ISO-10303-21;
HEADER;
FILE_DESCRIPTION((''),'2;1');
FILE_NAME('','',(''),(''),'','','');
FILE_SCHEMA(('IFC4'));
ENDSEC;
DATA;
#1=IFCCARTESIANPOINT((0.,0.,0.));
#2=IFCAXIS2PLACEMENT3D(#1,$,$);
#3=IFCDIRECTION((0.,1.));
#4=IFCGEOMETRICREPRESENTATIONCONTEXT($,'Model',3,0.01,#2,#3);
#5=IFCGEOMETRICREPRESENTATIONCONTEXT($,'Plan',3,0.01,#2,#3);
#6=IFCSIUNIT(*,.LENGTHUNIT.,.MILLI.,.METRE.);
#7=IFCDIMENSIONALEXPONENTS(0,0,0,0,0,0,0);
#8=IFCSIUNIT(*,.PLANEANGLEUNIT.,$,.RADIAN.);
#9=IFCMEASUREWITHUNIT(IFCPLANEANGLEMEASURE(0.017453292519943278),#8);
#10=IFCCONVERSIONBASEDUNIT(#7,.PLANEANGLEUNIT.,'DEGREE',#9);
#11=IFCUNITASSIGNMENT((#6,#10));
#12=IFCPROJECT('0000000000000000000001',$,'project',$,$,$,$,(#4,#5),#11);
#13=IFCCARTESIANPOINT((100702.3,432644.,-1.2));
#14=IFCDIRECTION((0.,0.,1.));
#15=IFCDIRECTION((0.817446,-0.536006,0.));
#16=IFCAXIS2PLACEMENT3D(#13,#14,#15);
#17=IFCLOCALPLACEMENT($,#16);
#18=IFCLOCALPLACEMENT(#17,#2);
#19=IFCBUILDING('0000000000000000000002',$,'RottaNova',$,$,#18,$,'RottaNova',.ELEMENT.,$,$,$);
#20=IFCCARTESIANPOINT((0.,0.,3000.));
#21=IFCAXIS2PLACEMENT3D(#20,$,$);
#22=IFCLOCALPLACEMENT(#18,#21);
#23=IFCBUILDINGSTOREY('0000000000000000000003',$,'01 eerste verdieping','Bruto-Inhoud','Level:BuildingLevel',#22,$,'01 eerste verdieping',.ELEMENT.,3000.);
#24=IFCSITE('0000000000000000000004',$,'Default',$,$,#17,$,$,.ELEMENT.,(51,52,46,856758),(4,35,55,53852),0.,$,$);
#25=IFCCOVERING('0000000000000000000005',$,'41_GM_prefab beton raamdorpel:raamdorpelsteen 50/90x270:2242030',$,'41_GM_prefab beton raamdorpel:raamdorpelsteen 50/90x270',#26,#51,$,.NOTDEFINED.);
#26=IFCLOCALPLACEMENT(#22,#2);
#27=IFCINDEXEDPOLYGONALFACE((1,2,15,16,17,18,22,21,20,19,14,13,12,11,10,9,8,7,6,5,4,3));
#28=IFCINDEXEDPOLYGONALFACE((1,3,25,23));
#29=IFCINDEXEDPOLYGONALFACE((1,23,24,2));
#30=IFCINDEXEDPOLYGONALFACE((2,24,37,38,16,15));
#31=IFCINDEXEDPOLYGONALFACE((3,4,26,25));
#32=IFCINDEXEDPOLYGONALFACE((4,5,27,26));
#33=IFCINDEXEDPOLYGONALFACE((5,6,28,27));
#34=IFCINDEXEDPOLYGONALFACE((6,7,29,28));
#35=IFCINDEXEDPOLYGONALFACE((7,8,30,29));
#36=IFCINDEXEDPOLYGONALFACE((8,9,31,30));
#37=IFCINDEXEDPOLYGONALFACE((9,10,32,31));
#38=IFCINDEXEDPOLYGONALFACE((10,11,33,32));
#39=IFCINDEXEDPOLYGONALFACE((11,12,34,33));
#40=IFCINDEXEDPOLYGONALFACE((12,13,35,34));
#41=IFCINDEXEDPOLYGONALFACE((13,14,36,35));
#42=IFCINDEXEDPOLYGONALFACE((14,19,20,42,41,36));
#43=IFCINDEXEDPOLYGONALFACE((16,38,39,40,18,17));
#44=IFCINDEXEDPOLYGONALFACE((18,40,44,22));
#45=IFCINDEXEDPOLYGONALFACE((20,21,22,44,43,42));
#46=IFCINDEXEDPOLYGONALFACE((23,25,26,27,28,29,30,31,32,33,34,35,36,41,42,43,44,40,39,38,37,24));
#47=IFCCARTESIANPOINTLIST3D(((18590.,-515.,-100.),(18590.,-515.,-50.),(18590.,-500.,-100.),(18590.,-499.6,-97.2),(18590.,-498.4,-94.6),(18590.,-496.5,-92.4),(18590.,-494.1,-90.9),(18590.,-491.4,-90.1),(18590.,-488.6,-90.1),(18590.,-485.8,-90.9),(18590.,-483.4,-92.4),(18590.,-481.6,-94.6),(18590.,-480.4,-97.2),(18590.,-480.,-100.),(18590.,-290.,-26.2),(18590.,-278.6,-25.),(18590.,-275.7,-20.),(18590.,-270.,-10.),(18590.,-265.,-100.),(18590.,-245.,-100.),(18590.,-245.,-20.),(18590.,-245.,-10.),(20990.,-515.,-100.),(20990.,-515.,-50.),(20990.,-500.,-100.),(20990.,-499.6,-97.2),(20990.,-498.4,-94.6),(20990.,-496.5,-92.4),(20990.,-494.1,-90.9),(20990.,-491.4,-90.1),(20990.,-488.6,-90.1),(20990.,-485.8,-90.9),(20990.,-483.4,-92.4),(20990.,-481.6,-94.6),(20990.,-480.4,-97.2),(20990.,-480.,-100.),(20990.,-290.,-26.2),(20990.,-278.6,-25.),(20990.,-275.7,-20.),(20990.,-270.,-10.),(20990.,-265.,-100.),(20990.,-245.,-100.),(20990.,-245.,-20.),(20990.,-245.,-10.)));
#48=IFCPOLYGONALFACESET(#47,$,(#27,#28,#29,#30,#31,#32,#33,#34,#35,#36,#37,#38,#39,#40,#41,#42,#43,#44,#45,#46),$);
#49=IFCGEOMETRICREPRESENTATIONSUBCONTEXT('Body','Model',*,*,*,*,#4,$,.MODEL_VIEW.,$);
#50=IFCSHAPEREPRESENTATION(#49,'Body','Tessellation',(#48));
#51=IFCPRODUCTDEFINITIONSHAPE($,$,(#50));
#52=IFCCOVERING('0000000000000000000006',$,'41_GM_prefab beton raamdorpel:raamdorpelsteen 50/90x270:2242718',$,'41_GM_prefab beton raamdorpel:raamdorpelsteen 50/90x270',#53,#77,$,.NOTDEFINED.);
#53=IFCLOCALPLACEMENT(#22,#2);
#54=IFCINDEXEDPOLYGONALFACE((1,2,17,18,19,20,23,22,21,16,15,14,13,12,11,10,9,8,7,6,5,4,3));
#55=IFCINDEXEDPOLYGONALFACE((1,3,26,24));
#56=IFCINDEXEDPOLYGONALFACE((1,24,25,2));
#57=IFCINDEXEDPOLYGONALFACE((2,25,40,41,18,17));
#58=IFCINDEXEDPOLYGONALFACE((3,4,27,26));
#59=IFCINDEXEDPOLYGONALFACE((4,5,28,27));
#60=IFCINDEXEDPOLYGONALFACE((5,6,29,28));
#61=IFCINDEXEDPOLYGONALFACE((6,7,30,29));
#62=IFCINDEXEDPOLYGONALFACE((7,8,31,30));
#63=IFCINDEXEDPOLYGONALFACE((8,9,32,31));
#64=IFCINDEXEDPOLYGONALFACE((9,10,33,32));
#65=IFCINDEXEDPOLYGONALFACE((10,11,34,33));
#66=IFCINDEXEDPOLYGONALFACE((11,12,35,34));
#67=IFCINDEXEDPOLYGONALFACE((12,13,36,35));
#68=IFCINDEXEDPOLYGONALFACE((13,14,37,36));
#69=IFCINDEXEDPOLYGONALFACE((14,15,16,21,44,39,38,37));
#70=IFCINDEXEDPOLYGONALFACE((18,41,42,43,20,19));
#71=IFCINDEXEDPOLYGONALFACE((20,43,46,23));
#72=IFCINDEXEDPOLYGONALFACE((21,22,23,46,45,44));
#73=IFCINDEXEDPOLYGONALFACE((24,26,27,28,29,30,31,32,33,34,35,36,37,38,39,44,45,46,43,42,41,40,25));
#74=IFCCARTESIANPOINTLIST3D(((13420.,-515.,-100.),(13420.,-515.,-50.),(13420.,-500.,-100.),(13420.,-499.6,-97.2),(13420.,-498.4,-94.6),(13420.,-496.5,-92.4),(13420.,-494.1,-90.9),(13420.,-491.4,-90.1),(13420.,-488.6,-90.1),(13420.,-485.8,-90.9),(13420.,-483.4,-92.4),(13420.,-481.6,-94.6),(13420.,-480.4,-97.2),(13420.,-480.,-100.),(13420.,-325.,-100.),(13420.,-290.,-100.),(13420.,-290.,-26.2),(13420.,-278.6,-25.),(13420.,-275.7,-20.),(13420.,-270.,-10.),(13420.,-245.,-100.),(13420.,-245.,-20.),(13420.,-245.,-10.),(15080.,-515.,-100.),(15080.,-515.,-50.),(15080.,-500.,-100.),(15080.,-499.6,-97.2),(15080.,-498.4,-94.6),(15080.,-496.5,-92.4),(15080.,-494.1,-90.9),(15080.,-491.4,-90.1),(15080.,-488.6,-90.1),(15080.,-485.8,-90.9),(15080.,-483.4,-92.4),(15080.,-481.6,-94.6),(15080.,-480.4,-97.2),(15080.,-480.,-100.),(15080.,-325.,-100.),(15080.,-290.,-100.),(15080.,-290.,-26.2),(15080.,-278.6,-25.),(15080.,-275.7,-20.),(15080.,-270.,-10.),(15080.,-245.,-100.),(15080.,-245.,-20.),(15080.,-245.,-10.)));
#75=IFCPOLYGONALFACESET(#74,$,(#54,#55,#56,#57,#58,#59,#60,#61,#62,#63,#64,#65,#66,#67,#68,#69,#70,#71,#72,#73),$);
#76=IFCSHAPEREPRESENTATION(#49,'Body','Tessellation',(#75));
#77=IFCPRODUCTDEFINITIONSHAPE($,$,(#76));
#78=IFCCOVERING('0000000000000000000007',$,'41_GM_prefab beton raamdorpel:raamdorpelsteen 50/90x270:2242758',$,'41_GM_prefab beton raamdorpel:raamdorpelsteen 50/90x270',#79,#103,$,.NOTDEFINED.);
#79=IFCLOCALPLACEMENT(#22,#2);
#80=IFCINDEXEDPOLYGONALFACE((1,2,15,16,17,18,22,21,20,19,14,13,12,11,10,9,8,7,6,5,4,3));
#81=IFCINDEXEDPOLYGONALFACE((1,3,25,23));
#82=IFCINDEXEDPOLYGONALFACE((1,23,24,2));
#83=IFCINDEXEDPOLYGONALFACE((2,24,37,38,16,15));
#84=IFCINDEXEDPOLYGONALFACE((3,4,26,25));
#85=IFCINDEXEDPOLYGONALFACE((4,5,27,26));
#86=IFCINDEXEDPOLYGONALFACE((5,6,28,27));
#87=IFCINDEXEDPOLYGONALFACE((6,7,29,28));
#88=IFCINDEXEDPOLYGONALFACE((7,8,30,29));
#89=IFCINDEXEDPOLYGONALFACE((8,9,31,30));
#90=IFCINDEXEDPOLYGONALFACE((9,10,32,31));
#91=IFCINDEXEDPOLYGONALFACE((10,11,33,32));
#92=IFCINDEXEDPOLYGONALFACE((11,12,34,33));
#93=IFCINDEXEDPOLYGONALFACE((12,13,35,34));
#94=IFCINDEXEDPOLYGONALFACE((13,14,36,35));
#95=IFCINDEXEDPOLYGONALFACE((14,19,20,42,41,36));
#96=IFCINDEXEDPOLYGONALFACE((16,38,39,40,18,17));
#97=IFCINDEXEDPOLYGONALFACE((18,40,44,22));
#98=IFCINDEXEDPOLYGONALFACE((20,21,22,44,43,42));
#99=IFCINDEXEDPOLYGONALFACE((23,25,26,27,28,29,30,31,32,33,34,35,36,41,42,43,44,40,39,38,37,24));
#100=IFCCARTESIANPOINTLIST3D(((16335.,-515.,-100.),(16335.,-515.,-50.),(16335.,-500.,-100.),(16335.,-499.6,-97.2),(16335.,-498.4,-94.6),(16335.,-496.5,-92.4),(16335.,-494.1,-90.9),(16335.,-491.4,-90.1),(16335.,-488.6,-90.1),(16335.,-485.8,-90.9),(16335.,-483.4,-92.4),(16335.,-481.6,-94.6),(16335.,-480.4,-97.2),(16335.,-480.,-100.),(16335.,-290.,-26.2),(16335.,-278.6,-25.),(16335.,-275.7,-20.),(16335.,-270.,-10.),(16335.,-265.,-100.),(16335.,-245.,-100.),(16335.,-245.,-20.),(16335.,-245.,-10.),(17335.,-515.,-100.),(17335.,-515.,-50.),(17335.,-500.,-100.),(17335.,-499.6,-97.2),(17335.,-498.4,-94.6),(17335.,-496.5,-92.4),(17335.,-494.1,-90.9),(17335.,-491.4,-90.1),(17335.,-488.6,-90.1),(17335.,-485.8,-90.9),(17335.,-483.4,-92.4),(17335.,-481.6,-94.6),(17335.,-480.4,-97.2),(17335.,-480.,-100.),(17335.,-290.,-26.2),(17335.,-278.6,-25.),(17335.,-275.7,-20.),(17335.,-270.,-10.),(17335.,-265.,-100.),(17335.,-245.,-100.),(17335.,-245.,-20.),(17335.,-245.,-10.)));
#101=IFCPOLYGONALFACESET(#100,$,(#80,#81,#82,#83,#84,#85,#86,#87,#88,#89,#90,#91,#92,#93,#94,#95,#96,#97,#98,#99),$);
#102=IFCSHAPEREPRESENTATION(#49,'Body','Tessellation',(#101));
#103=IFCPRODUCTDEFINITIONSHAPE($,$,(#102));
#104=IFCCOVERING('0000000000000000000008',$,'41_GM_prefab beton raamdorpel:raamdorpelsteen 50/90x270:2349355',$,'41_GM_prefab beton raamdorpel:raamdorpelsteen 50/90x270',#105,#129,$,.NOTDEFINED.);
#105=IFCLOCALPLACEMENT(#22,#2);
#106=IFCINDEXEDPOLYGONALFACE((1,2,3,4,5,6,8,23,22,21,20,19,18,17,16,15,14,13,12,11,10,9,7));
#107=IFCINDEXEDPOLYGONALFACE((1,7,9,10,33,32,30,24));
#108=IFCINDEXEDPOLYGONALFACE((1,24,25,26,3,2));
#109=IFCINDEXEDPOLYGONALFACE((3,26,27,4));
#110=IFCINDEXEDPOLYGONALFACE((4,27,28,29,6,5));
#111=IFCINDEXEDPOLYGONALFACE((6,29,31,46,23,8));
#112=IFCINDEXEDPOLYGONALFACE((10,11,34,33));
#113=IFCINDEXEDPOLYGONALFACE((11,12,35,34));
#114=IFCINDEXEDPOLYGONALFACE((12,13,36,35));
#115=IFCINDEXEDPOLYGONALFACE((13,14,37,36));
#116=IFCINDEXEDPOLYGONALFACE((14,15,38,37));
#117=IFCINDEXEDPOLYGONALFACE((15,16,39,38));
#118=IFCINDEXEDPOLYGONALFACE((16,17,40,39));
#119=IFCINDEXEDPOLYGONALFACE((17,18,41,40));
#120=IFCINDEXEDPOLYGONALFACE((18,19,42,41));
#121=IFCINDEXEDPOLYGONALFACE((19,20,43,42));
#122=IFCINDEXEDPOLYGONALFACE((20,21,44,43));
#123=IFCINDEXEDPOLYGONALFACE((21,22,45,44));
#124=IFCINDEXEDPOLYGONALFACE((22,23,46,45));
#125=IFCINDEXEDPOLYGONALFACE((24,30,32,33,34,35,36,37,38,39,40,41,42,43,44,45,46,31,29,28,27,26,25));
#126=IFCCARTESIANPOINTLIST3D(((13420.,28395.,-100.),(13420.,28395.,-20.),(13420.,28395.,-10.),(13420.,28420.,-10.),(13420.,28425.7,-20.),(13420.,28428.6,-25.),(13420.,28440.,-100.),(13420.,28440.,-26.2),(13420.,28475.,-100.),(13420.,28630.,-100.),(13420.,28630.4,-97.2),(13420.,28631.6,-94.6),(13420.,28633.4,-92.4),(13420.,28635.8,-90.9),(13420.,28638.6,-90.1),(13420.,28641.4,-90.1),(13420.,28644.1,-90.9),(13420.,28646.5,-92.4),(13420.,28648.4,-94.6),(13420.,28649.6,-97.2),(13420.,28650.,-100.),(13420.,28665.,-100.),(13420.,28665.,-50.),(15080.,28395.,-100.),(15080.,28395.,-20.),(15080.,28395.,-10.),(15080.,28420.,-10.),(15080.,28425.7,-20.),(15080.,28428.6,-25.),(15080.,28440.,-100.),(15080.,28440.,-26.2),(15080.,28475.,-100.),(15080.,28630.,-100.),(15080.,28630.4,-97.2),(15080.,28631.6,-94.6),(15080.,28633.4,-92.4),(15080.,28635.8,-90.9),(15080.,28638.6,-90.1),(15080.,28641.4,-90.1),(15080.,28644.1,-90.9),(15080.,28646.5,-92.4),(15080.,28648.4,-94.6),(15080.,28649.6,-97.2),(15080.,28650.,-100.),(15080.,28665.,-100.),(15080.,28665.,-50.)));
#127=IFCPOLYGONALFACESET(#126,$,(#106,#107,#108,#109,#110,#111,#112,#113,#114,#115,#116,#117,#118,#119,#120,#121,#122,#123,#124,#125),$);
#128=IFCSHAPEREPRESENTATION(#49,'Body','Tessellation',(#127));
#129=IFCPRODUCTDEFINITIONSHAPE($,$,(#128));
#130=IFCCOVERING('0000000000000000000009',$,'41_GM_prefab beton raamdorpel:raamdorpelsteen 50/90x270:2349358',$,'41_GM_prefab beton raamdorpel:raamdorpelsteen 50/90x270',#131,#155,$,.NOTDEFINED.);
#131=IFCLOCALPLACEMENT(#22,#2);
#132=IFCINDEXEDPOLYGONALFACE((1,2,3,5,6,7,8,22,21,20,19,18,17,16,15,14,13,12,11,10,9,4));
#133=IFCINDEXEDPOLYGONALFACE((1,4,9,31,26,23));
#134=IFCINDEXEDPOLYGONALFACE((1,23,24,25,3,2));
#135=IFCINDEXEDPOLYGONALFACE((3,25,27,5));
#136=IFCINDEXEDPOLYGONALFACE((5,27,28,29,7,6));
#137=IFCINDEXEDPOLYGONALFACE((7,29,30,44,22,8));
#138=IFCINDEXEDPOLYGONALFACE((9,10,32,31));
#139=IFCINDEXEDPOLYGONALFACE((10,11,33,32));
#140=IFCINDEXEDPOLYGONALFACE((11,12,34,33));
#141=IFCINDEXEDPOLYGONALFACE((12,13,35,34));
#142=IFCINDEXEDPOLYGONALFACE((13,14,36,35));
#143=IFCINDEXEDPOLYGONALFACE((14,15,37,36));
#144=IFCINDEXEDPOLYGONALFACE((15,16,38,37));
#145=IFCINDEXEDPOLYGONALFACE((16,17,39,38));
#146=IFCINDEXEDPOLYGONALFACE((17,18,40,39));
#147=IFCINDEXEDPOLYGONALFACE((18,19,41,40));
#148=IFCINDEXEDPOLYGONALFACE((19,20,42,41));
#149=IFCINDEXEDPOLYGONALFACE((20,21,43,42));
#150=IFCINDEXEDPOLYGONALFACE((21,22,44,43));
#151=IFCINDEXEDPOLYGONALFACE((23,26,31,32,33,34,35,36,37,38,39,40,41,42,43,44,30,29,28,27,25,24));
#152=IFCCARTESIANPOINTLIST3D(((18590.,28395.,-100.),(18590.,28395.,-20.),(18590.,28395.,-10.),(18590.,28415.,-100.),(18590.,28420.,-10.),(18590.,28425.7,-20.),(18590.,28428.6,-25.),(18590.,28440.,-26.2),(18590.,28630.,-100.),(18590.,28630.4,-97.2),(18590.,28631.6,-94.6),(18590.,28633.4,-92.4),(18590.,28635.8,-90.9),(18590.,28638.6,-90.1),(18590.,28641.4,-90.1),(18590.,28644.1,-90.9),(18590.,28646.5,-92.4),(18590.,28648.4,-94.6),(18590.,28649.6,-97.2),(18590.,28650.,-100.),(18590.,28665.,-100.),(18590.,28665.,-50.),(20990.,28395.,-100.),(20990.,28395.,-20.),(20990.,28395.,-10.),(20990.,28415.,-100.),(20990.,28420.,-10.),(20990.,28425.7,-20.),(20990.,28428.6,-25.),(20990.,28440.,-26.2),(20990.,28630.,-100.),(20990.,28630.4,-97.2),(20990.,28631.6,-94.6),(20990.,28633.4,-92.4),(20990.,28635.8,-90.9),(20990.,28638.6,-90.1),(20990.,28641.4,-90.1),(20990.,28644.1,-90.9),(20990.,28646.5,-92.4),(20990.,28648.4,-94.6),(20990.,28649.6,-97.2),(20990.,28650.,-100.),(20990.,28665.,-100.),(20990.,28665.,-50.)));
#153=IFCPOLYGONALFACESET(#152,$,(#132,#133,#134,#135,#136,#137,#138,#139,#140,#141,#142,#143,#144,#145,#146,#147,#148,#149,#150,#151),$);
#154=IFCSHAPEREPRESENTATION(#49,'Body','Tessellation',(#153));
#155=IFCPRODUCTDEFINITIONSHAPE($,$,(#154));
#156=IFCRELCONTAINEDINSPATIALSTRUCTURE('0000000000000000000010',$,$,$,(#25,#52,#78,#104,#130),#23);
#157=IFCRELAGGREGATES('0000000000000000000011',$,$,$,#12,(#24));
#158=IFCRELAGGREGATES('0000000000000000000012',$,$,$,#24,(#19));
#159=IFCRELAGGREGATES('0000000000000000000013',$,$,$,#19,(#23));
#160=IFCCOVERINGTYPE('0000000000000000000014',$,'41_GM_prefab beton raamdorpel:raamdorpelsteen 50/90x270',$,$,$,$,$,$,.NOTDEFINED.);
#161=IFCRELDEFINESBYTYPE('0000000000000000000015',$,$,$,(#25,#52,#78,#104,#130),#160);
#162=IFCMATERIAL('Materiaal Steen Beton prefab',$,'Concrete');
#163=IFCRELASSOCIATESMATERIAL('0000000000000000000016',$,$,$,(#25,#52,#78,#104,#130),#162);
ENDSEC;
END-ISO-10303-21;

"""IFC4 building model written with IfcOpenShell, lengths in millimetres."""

from ifc_helpers import new_model, entity, si_unit, converted_unit, direction, frame, origin, place, context, subcontext, project, spatial, line, arc, indexed_curve, outline, extrude, material, type_object, element, save


model = new_model("IFC4")

# Units and contexts
model_context = context("Model", 3, precision=0.01, world=origin(), true_north=direction((0.0, 1.0)))
plan_context = context("Plan", 3, precision=0.01, world=origin(), true_north=direction((0.0, 1.0)))
body_context = subcontext(model_context, "Body", "Model", "MODEL_VIEW")
ifc_project = project(units=[si_unit("LENGTHUNIT", "METRE", prefix="MILLI"), converted_unit("PLANEANGLEUNIT", "DEGREE", entity("IfcPlaneAngleMeasure", 0.017453292519943278), si_unit("PLANEANGLEUNIT", "RADIAN"), dimensions=[0, 0, 0, 0, 0, 0, 0])], contexts=[model_context, plan_context])

# Site, building, storey
site_placement = place(None, frame((100702.3, 432644.0, -1.2), z_axis=(0.0, 0.0, 1.0), x_axis=(0.817446, -0.536006, 0.0)))
site = spatial("IfcSite", under=ifc_project, at=site_placement, Name="Default", CompositionType="ELEMENT", RefLatitude=(51, 52, 46, 856758), RefLongitude=(4, 35, 55, 53852), RefElevation=0.0)
building_placement = place(site_placement, origin())
building = spatial("IfcBuilding", under=site, at=building_placement, Name="RottaNova", LongName="RottaNova", CompositionType="ELEMENT")
storey_placement = place(building_placement, frame((0.0, 0.0, 3000.0)))
storey = spatial("IfcBuildingStorey", under=building, at=storey_placement, Name="01 eerste verdieping", Description="Bruto-Inhoud", ObjectType="Level:BuildingLevel", LongName="01 eerste verdieping", CompositionType="ELEMENT", Elevation=3000.0)

# Shared definitions
ifc_material_1 = material(Name="Materiaal Steen Beton prefab", Category="Concrete")

# Coverings
covering_type_1 = type_object("IfcCoveringType", Name="41_GM_prefab beton raamdorpel:raamdorpelsteen 50/90x270", PredefinedType="NOTDEFINED")
covering_1_placement = place(storey_placement, origin())
element("IfcCovering", 1, at=covering_1_placement, inside=storey, type_object=covering_type_1, material=ifc_material_1, Name="41_GM_prefab beton raamdorpel:raamdorpelsteen 50/90x270:2242030", ObjectType="41_GM_prefab beton raamdorpel:raamdorpelsteen 50/90x270", PredefinedType="NOTDEFINED", context=body_context, shape_type="SweptSolid", body=[
    extrude(outline(indexed_curve([(-75.9, -41.3), (-88.4, -62.9), (-79.8, -67.9), (-10.5, -107.9), (-0.5, -90.6), (107.0, 95.6), (103.4, 109.3), (117.0, 112.9), (124.5, 125.9), (81.2, 150.9), (-51.9, -32.0), (-58.6, -41.3), (-64.4, -41.3)], segments=[line(1, 2, 3, 4, 5, 6), arc(6, 7, 8), line(8, 9, 10, 11, 12, 13, 1)], self_intersect=False)), frame((18590.0, -343.7, -55.1), z_axis=(-1.0, 0.0, 0.0), x_axis=(0.0, -0.5, -0.866025)), (0.0, 0.0, -1.0), 2400.0),
])
covering_2_placement = place(storey_placement, origin())
element("IfcCovering", 2, at=covering_2_placement, inside=storey, type_object=covering_type_1, material=ifc_material_1, Name="41_GM_prefab beton raamdorpel:raamdorpelsteen 50/90x270:2242718", ObjectType="41_GM_prefab beton raamdorpel:raamdorpelsteen 50/90x270", PredefinedType="NOTDEFINED", context=body_context, shape_type="SweptSolid", body=[
    extrude(outline(indexed_curve([(-79.1, -40.0), (-91.6, -61.6), (-83.0, -66.6), (-13.7, -106.6), (8.8, -67.6), (26.3, -37.3), (103.8, 96.9), (100.1, 110.6), (113.8, 114.2), (121.3, 127.2), (78.0, 152.2), (-55.1, -30.7), (-61.8, -40.0), (-67.6, -40.0)], segments=[line(1, 2, 3, 4, 5, 6, 7), arc(7, 8, 9), line(9, 10, 11, 12, 13, 14, 1)], self_intersect=False)), frame((13420.0, -344.2, -58.6), z_axis=(-1.0, 0.0, 0.0), x_axis=(0.0, -0.5, -0.866025)), (0.0, 0.0, -1.0), 1660.0),
])
covering_3_placement = place(storey_placement, origin())
element("IfcCovering", 3, at=covering_3_placement, inside=storey, type_object=covering_type_1, material=ifc_material_1, Name="41_GM_prefab beton raamdorpel:raamdorpelsteen 50/90x270:2242758", ObjectType="41_GM_prefab beton raamdorpel:raamdorpelsteen 50/90x270", PredefinedType="NOTDEFINED", context=body_context, shape_type="SweptSolid", body=[
    extrude(outline(indexed_curve([(-75.9, -41.3), (-88.4, -62.9), (-79.8, -67.9), (-10.5, -107.9), (-0.5, -90.6), (107.0, 95.6), (103.4, 109.3), (117.0, 112.9), (124.5, 125.9), (81.2, 150.9), (-51.9, -32.0), (-58.6, -41.3), (-64.4, -41.3)], segments=[line(1, 2, 3, 4, 5, 6), arc(6, 7, 8), line(8, 9, 10, 11, 12, 13, 1)], self_intersect=False)), frame((16335.0, -343.7, -55.1), z_axis=(-1.0, 0.0, 0.0), x_axis=(0.0, -0.5, -0.866025)), (0.0, 0.0, -1.0), 1000.0),
])
covering_4_placement = place(storey_placement, origin())
element("IfcCovering", 4, at=covering_4_placement, inside=storey, type_object=covering_type_1, material=ifc_material_1, Name="41_GM_prefab beton raamdorpel:raamdorpelsteen 50/90x270:2349355", ObjectType="41_GM_prefab beton raamdorpel:raamdorpelsteen 50/90x270", PredefinedType="NOTDEFINED", context=body_context, shape_type="SweptSolid", body=[
    extrude(outline(indexed_curve([(74.2, -48.6), (99.2, -48.6), (99.2, -38.6), (99.2, 41.4), (54.2, 41.4), (19.2, 41.4), (-135.8, 41.4), (-145.8, 31.4), (-155.8, 41.4), (-170.8, 41.4), (-170.8, -8.6), (54.2, -32.4), (65.5, -33.6), (68.4, -38.6)], segments=[line(1, 2, 3, 4, 5, 6, 7), arc(7, 8, 9), line(9, 10, 11, 12, 13, 14, 1)], self_intersect=False)), frame((13420.0, 28494.2, -58.6), z_axis=(1.0, 0.0, 0.0), x_axis=(0.0, -1.0, 0.0)), (0.0, 0.0, 1.0), 1660.0),
])
covering_5_placement = place(storey_placement, origin())
element("IfcCovering", 5, at=covering_5_placement, inside=storey, type_object=covering_type_1, material=ifc_material_1, Name="41_GM_prefab beton raamdorpel:raamdorpelsteen 50/90x270:2349358", ObjectType="41_GM_prefab beton raamdorpel:raamdorpelsteen 50/90x270", PredefinedType="NOTDEFINED", context=body_context, shape_type="SweptSolid", body=[
    extrude(outline(indexed_curve([(73.7, -45.1), (98.7, -45.1), (98.7, -35.1), (98.7, 44.9), (78.7, 44.9), (-136.3, 44.9), (-146.3, 34.9), (-156.3, 44.9), (-171.3, 44.9), (-171.3, -5.1), (53.7, -28.9), (65.0, -30.1), (67.9, -35.1)], segments=[line(1, 2, 3, 4, 5, 6), arc(6, 7, 8), line(8, 9, 10, 11, 12, 13, 1)], self_intersect=False)), frame((18590.0, 28493.7, -55.1), z_axis=(1.0, 0.0, 0.0), x_axis=(0.0, -1.0, 0.0)), (0.0, 0.0, 1.0), 2400.0),
])

save(model, "model.ifc")
